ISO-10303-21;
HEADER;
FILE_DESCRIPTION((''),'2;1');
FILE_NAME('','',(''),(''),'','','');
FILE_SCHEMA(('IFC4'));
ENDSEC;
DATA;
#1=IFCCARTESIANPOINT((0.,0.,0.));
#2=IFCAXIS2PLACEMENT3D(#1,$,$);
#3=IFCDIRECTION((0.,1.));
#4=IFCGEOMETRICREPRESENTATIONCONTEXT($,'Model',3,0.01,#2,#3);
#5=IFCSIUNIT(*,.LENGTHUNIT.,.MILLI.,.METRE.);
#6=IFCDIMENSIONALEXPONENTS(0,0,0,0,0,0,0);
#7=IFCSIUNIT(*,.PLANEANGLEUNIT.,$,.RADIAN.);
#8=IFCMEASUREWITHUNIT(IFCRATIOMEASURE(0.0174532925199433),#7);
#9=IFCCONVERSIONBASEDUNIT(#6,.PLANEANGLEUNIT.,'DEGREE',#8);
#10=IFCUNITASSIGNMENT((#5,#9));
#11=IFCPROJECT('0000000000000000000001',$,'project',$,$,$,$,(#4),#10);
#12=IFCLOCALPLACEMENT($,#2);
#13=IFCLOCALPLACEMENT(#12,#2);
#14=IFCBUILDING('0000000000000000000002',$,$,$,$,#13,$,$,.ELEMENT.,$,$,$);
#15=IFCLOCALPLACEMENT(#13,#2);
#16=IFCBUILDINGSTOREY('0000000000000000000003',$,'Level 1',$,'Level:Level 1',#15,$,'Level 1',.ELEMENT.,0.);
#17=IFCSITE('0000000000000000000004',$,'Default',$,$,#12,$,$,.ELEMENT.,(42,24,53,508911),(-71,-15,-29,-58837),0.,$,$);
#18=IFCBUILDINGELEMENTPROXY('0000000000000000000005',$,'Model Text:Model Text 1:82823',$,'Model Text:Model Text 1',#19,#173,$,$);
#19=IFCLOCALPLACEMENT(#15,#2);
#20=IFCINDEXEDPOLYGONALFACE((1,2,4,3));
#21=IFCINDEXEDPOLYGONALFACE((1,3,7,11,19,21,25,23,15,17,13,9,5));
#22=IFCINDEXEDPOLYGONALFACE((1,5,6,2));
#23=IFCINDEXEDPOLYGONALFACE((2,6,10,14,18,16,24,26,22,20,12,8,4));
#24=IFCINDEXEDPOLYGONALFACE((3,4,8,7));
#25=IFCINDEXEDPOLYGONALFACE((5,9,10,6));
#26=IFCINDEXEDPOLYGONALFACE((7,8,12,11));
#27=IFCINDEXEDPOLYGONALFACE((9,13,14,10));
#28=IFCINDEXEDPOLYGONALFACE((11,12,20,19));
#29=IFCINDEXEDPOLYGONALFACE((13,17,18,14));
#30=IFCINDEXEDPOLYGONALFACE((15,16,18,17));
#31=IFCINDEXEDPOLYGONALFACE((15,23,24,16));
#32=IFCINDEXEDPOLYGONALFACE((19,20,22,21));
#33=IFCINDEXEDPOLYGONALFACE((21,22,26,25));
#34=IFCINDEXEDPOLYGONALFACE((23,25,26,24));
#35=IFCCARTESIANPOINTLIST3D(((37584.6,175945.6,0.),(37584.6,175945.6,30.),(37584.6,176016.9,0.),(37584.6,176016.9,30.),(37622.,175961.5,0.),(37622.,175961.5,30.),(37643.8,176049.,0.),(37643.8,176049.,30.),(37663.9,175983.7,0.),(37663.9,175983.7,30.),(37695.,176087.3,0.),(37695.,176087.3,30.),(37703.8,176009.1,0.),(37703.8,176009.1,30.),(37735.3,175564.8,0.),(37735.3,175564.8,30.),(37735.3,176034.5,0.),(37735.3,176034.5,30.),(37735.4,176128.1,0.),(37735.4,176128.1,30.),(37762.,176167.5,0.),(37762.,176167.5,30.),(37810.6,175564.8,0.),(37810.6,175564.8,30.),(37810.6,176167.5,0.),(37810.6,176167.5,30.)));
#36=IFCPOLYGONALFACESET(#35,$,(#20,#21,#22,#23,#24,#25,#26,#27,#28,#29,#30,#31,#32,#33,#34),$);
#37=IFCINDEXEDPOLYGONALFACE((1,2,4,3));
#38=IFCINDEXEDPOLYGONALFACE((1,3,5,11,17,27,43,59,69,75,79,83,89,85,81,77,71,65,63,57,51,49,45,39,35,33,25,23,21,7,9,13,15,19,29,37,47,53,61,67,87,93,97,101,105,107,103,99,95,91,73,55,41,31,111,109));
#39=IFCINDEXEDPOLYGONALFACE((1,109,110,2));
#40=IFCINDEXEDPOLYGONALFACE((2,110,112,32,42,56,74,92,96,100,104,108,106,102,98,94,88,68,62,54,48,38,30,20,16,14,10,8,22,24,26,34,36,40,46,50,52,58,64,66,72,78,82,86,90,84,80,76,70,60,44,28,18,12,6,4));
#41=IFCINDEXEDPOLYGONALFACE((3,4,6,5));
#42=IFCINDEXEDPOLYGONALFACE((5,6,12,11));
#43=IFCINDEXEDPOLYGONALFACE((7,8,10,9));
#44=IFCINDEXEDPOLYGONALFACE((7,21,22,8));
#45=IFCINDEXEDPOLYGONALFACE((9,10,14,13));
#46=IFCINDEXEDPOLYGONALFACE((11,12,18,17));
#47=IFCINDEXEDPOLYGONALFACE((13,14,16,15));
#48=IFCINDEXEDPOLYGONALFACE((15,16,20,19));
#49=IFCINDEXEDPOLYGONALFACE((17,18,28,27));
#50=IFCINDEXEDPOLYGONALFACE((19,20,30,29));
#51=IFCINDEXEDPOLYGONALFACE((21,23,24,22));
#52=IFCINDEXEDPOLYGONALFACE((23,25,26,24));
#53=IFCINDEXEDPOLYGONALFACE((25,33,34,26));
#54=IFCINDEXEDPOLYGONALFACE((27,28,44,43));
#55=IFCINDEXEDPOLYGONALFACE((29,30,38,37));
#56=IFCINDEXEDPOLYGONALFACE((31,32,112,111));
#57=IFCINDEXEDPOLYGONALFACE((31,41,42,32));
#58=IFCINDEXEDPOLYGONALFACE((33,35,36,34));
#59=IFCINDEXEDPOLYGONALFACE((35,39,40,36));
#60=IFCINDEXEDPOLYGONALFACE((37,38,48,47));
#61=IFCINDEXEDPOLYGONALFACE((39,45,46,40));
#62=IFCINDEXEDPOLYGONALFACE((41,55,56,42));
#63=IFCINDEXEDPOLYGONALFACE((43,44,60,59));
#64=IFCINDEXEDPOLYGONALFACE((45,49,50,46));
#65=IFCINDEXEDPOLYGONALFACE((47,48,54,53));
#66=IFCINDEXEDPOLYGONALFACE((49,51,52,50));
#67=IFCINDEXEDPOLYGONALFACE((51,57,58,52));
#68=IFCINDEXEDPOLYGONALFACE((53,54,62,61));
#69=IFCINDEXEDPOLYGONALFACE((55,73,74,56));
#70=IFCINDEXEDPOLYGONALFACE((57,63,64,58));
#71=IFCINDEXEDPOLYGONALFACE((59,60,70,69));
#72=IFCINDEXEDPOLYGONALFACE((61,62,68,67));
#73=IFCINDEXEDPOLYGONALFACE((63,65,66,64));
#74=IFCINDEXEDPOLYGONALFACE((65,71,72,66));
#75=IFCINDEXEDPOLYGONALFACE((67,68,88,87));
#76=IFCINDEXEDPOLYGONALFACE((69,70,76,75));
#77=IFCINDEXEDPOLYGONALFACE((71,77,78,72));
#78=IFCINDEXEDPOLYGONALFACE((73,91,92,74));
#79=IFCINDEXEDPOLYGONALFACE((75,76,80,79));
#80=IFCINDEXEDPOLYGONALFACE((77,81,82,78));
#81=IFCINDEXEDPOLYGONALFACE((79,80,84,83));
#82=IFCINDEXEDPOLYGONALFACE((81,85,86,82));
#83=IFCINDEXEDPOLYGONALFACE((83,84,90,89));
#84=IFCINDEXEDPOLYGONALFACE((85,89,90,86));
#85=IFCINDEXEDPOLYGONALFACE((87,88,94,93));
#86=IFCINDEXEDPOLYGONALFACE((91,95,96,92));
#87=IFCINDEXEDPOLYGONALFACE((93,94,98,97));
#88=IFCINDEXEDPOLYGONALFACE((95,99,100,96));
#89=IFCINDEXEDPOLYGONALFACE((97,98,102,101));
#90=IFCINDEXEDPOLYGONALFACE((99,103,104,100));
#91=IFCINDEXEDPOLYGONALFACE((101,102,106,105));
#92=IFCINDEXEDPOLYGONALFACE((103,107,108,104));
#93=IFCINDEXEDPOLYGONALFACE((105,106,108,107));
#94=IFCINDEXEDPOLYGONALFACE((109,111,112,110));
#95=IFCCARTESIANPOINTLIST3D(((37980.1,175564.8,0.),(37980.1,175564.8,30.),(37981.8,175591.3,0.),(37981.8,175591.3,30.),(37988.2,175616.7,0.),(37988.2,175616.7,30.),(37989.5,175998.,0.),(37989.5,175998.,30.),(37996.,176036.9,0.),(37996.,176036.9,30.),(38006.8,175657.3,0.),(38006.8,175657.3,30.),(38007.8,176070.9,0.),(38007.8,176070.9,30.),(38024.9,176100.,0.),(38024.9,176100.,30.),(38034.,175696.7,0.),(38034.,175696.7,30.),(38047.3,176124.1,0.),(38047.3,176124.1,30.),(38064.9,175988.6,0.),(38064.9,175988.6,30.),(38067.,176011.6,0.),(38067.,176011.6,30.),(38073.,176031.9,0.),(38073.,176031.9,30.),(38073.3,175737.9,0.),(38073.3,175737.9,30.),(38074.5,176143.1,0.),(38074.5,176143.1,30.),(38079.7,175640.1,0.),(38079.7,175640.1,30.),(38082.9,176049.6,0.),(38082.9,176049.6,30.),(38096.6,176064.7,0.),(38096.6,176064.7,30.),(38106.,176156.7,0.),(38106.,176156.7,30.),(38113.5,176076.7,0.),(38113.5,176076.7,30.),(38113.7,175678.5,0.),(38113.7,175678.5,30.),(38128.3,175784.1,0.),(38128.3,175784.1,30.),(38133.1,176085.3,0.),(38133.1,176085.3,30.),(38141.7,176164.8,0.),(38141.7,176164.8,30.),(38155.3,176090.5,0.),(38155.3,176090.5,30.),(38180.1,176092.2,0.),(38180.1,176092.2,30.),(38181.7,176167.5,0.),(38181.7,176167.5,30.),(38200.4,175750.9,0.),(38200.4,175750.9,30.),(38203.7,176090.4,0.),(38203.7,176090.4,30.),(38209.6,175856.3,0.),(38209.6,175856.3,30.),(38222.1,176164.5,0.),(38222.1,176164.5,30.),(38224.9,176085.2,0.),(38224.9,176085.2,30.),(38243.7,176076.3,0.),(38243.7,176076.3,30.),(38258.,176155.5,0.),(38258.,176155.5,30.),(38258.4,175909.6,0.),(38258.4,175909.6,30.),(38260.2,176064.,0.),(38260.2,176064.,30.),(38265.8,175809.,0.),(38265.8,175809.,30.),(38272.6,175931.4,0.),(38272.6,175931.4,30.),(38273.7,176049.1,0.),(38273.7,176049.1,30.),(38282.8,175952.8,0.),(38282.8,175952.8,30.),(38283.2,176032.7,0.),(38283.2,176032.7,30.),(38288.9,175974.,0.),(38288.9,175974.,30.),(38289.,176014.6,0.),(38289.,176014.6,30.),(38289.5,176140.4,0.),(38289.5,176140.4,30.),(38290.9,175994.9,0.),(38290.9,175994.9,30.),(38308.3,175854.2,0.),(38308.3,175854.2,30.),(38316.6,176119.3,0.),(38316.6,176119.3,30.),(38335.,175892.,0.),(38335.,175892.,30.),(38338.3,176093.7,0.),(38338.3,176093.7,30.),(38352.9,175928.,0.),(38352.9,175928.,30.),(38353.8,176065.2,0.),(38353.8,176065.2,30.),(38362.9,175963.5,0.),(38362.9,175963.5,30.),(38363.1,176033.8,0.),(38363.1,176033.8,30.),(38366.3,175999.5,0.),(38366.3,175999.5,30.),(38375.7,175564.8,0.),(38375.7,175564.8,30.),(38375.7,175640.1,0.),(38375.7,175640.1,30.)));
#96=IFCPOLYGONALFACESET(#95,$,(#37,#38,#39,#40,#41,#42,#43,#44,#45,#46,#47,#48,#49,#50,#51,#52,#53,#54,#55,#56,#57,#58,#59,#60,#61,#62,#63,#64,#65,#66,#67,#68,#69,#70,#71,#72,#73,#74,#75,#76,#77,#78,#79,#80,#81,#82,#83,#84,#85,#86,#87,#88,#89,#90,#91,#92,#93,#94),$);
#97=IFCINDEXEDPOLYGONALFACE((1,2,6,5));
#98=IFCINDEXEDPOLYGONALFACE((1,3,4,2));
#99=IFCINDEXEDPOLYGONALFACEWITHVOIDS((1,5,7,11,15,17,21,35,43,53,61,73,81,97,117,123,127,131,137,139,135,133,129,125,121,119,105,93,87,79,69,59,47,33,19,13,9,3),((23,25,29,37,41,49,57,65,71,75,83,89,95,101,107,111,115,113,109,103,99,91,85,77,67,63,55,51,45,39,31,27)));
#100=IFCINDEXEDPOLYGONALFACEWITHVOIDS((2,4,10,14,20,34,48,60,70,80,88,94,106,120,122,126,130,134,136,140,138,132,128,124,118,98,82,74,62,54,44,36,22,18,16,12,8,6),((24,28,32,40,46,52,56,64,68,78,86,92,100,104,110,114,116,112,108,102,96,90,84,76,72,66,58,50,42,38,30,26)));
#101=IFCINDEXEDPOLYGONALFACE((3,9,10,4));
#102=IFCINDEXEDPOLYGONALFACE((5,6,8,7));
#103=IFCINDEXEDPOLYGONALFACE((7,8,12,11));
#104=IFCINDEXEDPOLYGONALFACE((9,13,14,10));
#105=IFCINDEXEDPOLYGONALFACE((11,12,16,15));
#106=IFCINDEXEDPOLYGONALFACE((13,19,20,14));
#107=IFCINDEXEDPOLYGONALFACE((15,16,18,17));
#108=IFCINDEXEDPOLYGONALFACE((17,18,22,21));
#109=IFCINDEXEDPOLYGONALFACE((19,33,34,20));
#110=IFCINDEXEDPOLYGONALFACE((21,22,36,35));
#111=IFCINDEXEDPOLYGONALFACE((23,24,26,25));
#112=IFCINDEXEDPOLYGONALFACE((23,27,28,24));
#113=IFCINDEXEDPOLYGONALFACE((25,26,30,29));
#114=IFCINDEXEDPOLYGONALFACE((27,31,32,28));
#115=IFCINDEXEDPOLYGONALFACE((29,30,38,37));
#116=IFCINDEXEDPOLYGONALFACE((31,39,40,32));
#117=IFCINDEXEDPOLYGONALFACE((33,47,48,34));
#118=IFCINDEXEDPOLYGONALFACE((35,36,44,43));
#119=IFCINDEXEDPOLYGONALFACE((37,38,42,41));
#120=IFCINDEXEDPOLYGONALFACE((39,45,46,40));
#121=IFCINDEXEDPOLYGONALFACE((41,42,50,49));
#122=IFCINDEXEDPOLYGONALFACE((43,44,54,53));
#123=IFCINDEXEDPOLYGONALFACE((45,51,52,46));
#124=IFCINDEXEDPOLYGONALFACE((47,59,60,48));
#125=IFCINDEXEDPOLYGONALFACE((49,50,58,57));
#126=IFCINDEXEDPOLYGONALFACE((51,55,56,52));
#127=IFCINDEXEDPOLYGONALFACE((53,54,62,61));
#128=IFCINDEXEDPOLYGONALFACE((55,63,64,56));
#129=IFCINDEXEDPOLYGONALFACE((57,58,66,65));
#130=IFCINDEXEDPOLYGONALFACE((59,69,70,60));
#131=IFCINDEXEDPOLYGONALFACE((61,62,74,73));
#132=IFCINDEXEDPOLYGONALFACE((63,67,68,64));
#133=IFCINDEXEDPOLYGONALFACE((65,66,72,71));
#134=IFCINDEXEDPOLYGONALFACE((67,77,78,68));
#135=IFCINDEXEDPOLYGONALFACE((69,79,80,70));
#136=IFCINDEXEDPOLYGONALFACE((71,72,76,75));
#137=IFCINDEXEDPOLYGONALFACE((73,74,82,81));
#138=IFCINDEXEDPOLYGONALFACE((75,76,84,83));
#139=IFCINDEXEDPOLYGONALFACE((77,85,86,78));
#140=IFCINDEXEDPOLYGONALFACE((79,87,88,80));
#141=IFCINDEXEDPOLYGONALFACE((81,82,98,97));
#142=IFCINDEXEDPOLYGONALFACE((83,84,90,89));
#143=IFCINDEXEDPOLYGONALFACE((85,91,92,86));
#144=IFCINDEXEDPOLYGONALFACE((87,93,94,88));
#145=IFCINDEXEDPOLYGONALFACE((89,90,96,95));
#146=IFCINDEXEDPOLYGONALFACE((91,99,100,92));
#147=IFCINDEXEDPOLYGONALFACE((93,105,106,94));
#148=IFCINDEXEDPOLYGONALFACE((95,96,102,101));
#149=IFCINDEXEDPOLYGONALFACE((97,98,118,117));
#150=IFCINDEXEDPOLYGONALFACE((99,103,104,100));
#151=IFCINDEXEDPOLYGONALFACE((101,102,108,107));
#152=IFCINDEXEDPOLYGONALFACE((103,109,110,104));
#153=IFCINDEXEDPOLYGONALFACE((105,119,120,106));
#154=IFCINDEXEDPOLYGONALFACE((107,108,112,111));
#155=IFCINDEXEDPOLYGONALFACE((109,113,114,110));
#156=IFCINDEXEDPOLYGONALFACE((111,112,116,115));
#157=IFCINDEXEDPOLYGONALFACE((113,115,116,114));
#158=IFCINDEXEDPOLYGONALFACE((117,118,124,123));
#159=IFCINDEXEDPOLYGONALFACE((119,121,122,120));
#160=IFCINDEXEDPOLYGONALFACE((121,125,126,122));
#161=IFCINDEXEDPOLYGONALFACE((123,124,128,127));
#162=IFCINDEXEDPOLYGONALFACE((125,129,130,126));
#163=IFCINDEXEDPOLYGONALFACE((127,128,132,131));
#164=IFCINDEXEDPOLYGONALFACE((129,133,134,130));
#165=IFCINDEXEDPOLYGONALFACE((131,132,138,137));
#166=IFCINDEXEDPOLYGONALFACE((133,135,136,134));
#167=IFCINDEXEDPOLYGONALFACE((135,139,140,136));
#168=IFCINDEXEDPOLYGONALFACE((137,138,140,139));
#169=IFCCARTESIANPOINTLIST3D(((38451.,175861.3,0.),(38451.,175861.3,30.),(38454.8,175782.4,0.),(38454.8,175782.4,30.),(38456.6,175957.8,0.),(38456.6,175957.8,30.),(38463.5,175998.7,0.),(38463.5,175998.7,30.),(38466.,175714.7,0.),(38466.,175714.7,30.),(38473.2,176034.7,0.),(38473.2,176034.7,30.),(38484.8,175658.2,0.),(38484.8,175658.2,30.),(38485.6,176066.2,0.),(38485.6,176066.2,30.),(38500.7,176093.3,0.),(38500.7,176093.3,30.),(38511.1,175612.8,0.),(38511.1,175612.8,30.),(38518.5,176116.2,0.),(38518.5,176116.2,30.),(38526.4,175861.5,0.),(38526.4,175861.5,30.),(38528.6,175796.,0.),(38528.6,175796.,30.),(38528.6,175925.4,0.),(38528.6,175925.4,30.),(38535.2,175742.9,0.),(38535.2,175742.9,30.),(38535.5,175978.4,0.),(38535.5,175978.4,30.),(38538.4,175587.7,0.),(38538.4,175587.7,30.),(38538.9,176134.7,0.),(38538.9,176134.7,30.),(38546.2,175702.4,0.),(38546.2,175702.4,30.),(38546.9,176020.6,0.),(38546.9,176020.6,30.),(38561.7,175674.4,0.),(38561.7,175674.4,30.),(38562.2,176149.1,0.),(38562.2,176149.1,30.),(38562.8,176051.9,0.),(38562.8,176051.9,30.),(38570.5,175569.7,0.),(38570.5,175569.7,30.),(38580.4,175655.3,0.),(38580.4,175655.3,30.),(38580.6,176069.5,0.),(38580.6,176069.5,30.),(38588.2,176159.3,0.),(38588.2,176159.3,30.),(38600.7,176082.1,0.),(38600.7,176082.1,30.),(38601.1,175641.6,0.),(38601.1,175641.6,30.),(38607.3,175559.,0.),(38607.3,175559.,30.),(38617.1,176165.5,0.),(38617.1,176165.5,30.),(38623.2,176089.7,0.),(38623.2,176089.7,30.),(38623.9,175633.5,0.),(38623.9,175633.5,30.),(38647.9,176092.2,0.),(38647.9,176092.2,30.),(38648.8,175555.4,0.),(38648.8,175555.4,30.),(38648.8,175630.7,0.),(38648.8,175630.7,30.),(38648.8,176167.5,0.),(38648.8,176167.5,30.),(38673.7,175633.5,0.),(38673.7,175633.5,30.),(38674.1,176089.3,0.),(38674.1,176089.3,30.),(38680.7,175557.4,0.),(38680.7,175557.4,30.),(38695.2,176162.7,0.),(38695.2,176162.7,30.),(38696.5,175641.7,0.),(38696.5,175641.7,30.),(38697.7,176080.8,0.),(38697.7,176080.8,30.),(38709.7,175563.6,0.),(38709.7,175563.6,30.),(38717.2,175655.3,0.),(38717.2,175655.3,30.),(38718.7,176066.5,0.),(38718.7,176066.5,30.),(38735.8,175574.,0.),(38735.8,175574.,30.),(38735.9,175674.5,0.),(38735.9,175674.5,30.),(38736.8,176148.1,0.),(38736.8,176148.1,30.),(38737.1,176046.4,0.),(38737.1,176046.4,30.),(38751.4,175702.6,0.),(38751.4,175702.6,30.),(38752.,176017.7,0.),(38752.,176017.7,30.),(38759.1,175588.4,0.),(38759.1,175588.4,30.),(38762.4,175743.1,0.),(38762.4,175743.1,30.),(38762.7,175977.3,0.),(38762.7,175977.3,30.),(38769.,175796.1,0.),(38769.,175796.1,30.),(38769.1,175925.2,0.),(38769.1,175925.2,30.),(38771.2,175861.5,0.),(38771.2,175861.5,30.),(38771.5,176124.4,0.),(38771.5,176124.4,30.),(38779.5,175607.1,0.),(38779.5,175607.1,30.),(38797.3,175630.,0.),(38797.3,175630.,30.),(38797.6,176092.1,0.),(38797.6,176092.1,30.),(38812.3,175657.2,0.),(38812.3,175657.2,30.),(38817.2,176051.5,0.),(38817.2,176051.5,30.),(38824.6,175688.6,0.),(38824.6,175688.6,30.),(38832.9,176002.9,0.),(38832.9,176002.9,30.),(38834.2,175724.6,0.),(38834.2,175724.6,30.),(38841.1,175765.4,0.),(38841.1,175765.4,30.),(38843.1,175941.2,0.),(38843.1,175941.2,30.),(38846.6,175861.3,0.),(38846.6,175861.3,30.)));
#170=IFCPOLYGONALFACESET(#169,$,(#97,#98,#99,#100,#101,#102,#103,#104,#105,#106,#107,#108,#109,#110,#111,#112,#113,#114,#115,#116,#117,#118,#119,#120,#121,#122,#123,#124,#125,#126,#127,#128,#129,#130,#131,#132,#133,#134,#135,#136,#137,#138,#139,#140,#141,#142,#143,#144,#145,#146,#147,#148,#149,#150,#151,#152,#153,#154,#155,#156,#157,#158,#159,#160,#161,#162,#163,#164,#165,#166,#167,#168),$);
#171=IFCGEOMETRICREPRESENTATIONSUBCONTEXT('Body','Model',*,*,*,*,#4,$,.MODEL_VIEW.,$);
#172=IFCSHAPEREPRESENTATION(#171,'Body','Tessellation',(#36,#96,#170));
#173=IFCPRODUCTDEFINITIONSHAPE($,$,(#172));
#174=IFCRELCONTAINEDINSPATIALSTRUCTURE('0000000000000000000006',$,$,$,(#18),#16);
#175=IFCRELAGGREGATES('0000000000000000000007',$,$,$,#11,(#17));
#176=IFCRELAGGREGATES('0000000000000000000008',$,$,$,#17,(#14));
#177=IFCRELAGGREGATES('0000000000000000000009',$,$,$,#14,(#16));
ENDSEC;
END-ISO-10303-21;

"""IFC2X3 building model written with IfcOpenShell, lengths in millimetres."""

from ifc_helpers import new_model, entity, si_unit, converted_unit, direction, frame, origin, place, context, subcontext, project, spatial, polyline, outline, extrude, element, save


model = new_model("IFC2X3")

# Units and contexts
model_context = context("Model", 3, precision=0.01, world=origin(), true_north=direction((0.0, 1.0)))
body_context = subcontext(model_context, "Body", "Model", "MODEL_VIEW")
ifc_project = project(units=[si_unit("LENGTHUNIT", "METRE", prefix="MILLI"), converted_unit("PLANEANGLEUNIT", "DEGREE", entity("IfcRatioMeasure", 0.0174532925199433), si_unit("PLANEANGLEUNIT", "RADIAN"), dimensions=[0, 0, 0, 0, 0, 0, 0])], contexts=[model_context])

# Site, building, storey
site_placement = place(None, origin())
site = spatial("IfcSite", under=ifc_project, at=site_placement, Name="Default", CompositionType="ELEMENT", RefLatitude=(42, 24, 53, 508911), RefLongitude=(-71, -15, -29, -58837), RefElevation=0.0)
building_placement = place(site_placement, origin())
building = spatial("IfcBuilding", under=site, at=building_placement, CompositionType="ELEMENT")
storey_placement = place(building_placement, origin())
storey = spatial("IfcBuildingStorey", under=building, at=storey_placement, Name="Level 1", ObjectType="Level:Level 1", LongName="Level 1", CompositionType="ELEMENT", Elevation=0.0)

# Building element proxy
proxy_1_placement = place(storey_placement, origin())
element("IfcBuildingElementProxy", 1, at=proxy_1_placement, inside=storey, Name="Model Text:Model Text 1:82823", ObjectType="Model Text:Model Text 1", context=body_context, shape_type="SweptSolid", body=[
    extrude(outline(polyline([(-410.6, -111.6), (192.1, -111.6), (192.1, -63.1), (152.7, -36.4), (111.9, 4.0), (73.6, 55.2), (41.4, 114.4), (-29.8, 114.4), (-13.9, 77.0), (8.3, 35.1), (33.7, -4.8), (59.1, -36.3), (-410.6, -36.3), (-410.6, -111.6)])), frame((37699.0, 175975.4, 0.0), z_axis=(0.0, 0.0, 1.0), x_axis=(0.0, 1.0, 0.0)), (0.0, 0.0, 1.0), 30.0),
    extrude(outline(polyline([(-190.2, -317.5), (-190.2, -392.8), (205.4, -392.8), (203.7, -366.3), (197.3, -340.9), (178.7, -300.3), (151.5, -260.9), (112.2, -219.7), (57.2, -173.6), (-24.1, -101.3), (-72.9, -48.0), (-87.1, -26.3), (-97.3, -4.8), (-103.4, 16.4), (-105.4, 37.3), (-103.5, 57.0), (-97.7, 75.0), (-88.2, 91.5), (-74.7, 106.4), (-58.2, 118.7), (-39.4, 127.5), (-18.2, 132.8), (5.4, 134.6), (30.2, 132.9), (52.4, 127.7), (72.0, 119.1), (88.9, 107.1), (102.6, 92.0), (112.5, 74.3), (118.5, 54.0), (120.6, 31.0), (196.0, 40.4), (189.5, 79.3), (177.7, 113.3), (160.6, 142.4), (138.2, 166.5), (111.0, 185.5), (79.5, 199.1), (43.8, 207.2), (3.8, 209.9), (-36.6, 206.9), (-72.5, 197.9), (-104.0, 182.8), (-131.1, 161.7), (-152.8, 136.1), (-168.3, 107.6), (-177.6, 76.2), (-180.8, 41.9), (-177.4, 5.8), (-167.4, -29.6), (-149.5, -65.6), (-122.8, -103.4), (-80.3, -148.6), (-14.9, -206.7), (71.8, -279.1), (105.8, -317.5), (-190.2, -317.5)])), frame((38185.5, 175957.6, 0.0), z_axis=(0.0, 0.0, -1.0), x_axis=(-1.0, 0.0, 0.0)), (0.0, 0.0, -1.0), 30.0),
    extrude(outline(polyline([(-10.6, -198.7), (68.3, -198.7), (136.5, -190.7), (193.9, -174.7), (240.5, -150.6), (266.9, -124.4), (286.3, -93.2), (298.8, -57.0), (304.3, -15.7), (303.8, 16.2), (299.0, 45.5), (289.9, 72.1), (276.6, 96.0), (258.9, 117.3), (236.9, 136.2), (210.4, 152.5), (179.6, 166.3), (144.1, 177.6), (103.7, 186.3), (8.2, 196.4), (-71.8, 196.7), (-134.0, 189.4), (-183.3, 176.1), (-224.7, 158.4), (-258.2, 133.9), (-283.5, 100.3), (-300.1, 59.5), (-307.1, 13.4), (-306.6, -18.4), (-301.8, -47.5), (-292.8, -74.0), (-279.6, -97.9), (-262.0, -119.2), (-240.0, -138.1), (-213.6, -154.5), (-182.8, -168.4), (-147.3, -179.8), (-106.7, -188.6), (-10.6, -198.7)]), holes=[polyline([(-7.2, -123.5), (-71.0, -118.2), (-123.6, -108.8), (-165.2, -95.4), (-195.7, -78.0), (-212.4, -59.4), (-224.1, -38.7), (-230.6, -15.9), (-231.9, 8.9), (-227.8, 35.0), (-218.1, 58.1), (-202.8, 78.4), (-182.0, 95.8), (-152.6, 109.4), (-111.7, 118.1), (-59.4, 122.0), (4.4, 121.1), (69.6, 115.8), (122.2, 106.7), (162.2, 93.7), (189.5, 77.0), (207.7, 57.4), (220.4, 36.0), (227.5, 12.8), (229.1, -12.1), (225.2, -36.8), (215.9, -59.2), (201.3, -79.3), (181.4, -97.1), (152.6, -111.2), (111.6, -120.3), (58.3, -124.4), (-7.2, -123.5)])]), frame((38650.0, 175860.1, 0.0), z_axis=(0.0, 0.0, 1.0), x_axis=(0.047515, -0.998871, 0.0)), (0.0, 0.0, 1.0), 30.0),
])

save(model, "model.ifc")
